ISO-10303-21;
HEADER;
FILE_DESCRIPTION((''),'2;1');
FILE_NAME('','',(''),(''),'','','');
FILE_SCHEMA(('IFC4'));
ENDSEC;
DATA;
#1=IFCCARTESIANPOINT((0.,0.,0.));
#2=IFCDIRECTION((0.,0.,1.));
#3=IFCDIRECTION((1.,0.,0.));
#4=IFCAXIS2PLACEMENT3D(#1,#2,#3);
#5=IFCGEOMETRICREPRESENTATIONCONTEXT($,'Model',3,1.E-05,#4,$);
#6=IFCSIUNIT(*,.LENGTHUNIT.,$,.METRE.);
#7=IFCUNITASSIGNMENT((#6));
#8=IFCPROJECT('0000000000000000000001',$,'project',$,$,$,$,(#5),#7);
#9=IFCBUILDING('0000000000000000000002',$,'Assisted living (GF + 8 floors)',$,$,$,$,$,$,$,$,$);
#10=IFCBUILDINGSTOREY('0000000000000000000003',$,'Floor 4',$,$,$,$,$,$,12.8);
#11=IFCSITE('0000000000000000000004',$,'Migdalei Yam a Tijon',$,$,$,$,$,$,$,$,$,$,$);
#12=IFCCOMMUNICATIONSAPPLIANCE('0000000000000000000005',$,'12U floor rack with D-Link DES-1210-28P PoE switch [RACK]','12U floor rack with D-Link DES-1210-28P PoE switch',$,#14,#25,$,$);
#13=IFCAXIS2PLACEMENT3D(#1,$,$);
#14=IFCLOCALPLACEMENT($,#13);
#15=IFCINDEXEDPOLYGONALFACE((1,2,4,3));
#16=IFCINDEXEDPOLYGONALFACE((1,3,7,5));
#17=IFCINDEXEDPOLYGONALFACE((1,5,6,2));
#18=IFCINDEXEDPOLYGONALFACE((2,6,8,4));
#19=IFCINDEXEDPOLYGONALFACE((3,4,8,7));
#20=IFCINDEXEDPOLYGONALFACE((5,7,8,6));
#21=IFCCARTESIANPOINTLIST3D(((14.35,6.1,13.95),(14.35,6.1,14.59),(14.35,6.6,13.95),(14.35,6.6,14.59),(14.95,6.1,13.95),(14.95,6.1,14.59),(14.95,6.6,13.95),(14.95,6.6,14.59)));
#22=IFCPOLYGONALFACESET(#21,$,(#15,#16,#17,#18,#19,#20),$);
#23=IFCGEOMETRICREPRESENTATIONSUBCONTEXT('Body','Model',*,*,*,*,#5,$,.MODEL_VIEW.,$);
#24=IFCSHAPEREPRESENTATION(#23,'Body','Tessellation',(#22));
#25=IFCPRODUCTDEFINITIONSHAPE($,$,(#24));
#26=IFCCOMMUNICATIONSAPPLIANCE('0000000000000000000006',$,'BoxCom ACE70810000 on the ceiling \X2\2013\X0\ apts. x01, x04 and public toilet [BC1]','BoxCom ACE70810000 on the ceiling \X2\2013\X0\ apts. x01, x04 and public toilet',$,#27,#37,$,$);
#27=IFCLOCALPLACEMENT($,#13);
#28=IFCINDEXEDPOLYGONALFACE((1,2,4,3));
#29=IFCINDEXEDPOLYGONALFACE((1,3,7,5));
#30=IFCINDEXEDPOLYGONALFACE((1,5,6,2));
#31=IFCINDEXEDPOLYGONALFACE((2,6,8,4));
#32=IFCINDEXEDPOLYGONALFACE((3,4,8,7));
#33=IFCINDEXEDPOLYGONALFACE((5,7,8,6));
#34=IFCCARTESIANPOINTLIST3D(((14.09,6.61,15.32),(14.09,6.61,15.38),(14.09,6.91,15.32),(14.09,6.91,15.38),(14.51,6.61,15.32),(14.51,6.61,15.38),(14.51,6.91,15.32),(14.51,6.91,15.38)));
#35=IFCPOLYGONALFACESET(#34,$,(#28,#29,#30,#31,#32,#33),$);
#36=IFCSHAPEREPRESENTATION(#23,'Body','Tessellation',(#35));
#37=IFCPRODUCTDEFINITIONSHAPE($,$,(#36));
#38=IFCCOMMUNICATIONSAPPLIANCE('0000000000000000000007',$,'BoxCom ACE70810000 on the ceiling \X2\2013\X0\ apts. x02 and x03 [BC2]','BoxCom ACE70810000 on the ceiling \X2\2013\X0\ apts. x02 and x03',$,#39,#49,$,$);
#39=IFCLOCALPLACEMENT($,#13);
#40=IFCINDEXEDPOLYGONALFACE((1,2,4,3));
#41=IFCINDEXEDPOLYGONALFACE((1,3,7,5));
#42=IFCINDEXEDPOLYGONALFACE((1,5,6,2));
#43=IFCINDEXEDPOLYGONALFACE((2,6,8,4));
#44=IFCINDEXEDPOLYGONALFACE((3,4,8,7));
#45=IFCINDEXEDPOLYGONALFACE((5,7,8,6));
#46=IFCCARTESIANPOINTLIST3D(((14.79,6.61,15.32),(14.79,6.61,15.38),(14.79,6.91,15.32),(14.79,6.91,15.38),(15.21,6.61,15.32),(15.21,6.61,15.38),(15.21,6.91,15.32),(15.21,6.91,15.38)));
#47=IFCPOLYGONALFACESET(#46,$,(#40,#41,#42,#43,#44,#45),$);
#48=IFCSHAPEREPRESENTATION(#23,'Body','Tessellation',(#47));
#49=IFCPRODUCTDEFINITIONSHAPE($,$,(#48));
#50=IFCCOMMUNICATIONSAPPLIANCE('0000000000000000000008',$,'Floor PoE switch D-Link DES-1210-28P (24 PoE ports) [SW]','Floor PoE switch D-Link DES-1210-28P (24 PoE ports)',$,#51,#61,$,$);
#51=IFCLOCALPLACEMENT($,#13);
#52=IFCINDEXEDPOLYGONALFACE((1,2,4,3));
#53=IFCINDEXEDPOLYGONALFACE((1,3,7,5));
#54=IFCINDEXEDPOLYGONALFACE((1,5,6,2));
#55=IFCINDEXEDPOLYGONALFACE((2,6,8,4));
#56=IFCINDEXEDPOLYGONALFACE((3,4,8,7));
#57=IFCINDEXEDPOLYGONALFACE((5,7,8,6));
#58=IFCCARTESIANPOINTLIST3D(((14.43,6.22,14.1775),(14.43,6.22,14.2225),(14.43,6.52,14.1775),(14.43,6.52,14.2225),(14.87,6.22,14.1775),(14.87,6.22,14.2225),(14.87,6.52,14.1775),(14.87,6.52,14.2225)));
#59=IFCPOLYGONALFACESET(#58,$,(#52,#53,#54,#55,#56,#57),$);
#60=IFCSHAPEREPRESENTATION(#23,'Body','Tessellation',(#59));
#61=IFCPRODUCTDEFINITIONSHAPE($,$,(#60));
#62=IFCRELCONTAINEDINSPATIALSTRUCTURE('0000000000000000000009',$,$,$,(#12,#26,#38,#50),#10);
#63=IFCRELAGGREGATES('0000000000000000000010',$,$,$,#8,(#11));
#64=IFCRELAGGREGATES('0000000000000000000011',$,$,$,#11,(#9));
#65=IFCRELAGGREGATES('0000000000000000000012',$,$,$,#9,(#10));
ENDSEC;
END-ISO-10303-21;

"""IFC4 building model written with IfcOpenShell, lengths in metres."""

from ifc_helpers import new_model, si_unit, frame, origin_with_axes, context, subcontext, project, spatial, line, indexed_curve, outline, extrude, element, save


model = new_model("IFC4")

# Units and contexts
model_context = context("Model", 3, precision=1e-05, world=origin_with_axes())
body_context = subcontext(model_context, "Body", "Model", "MODEL_VIEW")
ifc_project = project(units=[si_unit("LENGTHUNIT", "METRE")], contexts=[model_context])

# Site, building, storey
site = spatial("IfcSite", under=ifc_project, Name="Migdalei Yam a Tijon")
building = spatial("IfcBuilding", under=site, Name="Assisted living (GF + 8 floors)")
storey = spatial("IfcBuildingStorey", under=building, Name="Floor 4", Elevation=12.8)

# Communications appliances
element("IfcCommunicationsAppliance", 1, inside=storey, Name="12U floor rack with D-Link DES-1210-28P PoE switch [RACK]", Description="12U floor rack with D-Link DES-1210-28P PoE switch", context=body_context, shape_type="SweptSolid", body=[
    extrude(outline(indexed_curve([(0.0, 0.0), (0.6, 0.0), (0.6, 0.5), (0.0, 0.5)], segments=[line(1, 2, 3, 4, 1)])), frame((14.35, 6.1, 13.95), z_axis=(0.0, 0.0, 1.0), x_axis=(1.0, 0.0, 0.0)), (0.0, 0.0, 1.0), 0.64),
])
element("IfcCommunicationsAppliance", 2, inside=storey, Name="BoxCom ACE70810000 on the ceiling – apts. x01, x04 and public toilet [BC1]", Description="BoxCom ACE70810000 on the ceiling – apts. x01, x04 and public toilet", context=body_context, shape_type="SweptSolid", body=[
    extrude(outline(indexed_curve([(0.0, 0.0), (0.42, 0.0), (0.42, 0.3), (0.0, 0.3)], segments=[line(1, 2, 3, 4, 1)])), frame((14.09, 6.61, 15.32), z_axis=(0.0, 0.0, 1.0), x_axis=(1.0, 0.0, 0.0)), (0.0, 0.0, 1.0), 0.06),
])
element("IfcCommunicationsAppliance", 3, inside=storey, Name="BoxCom ACE70810000 on the ceiling – apts. x02 and x03 [BC2]", Description="BoxCom ACE70810000 on the ceiling – apts. x02 and x03", context=body_context, shape_type="SweptSolid", body=[
    extrude(outline(indexed_curve([(0.0, 0.0), (0.42, 0.0), (0.42, 0.3), (0.0, 0.3)], segments=[line(1, 2, 3, 4, 1)])), frame((14.79, 6.61, 15.32), z_axis=(0.0, 0.0, 1.0), x_axis=(1.0, 0.0, 0.0)), (0.0, 0.0, 1.0), 0.06),
])
element("IfcCommunicationsAppliance", 4, inside=storey, Name="Floor PoE switch D-Link DES-1210-28P (24 PoE ports) [SW]", Description="Floor PoE switch D-Link DES-1210-28P (24 PoE ports)", context=body_context, shape_type="SweptSolid", body=[
    extrude(outline(indexed_curve([(0.0, 0.0), (0.44, 0.0), (0.44, 0.3), (0.0, 0.3)], segments=[line(1, 2, 3, 4, 1)])), frame((14.43, 6.22, 14.1775), z_axis=(0.0, 0.0, 1.0), x_axis=(1.0, 0.0, 0.0)), (0.0, 0.0, 1.0), 0.045),
])

save(model, "model.ifc")
